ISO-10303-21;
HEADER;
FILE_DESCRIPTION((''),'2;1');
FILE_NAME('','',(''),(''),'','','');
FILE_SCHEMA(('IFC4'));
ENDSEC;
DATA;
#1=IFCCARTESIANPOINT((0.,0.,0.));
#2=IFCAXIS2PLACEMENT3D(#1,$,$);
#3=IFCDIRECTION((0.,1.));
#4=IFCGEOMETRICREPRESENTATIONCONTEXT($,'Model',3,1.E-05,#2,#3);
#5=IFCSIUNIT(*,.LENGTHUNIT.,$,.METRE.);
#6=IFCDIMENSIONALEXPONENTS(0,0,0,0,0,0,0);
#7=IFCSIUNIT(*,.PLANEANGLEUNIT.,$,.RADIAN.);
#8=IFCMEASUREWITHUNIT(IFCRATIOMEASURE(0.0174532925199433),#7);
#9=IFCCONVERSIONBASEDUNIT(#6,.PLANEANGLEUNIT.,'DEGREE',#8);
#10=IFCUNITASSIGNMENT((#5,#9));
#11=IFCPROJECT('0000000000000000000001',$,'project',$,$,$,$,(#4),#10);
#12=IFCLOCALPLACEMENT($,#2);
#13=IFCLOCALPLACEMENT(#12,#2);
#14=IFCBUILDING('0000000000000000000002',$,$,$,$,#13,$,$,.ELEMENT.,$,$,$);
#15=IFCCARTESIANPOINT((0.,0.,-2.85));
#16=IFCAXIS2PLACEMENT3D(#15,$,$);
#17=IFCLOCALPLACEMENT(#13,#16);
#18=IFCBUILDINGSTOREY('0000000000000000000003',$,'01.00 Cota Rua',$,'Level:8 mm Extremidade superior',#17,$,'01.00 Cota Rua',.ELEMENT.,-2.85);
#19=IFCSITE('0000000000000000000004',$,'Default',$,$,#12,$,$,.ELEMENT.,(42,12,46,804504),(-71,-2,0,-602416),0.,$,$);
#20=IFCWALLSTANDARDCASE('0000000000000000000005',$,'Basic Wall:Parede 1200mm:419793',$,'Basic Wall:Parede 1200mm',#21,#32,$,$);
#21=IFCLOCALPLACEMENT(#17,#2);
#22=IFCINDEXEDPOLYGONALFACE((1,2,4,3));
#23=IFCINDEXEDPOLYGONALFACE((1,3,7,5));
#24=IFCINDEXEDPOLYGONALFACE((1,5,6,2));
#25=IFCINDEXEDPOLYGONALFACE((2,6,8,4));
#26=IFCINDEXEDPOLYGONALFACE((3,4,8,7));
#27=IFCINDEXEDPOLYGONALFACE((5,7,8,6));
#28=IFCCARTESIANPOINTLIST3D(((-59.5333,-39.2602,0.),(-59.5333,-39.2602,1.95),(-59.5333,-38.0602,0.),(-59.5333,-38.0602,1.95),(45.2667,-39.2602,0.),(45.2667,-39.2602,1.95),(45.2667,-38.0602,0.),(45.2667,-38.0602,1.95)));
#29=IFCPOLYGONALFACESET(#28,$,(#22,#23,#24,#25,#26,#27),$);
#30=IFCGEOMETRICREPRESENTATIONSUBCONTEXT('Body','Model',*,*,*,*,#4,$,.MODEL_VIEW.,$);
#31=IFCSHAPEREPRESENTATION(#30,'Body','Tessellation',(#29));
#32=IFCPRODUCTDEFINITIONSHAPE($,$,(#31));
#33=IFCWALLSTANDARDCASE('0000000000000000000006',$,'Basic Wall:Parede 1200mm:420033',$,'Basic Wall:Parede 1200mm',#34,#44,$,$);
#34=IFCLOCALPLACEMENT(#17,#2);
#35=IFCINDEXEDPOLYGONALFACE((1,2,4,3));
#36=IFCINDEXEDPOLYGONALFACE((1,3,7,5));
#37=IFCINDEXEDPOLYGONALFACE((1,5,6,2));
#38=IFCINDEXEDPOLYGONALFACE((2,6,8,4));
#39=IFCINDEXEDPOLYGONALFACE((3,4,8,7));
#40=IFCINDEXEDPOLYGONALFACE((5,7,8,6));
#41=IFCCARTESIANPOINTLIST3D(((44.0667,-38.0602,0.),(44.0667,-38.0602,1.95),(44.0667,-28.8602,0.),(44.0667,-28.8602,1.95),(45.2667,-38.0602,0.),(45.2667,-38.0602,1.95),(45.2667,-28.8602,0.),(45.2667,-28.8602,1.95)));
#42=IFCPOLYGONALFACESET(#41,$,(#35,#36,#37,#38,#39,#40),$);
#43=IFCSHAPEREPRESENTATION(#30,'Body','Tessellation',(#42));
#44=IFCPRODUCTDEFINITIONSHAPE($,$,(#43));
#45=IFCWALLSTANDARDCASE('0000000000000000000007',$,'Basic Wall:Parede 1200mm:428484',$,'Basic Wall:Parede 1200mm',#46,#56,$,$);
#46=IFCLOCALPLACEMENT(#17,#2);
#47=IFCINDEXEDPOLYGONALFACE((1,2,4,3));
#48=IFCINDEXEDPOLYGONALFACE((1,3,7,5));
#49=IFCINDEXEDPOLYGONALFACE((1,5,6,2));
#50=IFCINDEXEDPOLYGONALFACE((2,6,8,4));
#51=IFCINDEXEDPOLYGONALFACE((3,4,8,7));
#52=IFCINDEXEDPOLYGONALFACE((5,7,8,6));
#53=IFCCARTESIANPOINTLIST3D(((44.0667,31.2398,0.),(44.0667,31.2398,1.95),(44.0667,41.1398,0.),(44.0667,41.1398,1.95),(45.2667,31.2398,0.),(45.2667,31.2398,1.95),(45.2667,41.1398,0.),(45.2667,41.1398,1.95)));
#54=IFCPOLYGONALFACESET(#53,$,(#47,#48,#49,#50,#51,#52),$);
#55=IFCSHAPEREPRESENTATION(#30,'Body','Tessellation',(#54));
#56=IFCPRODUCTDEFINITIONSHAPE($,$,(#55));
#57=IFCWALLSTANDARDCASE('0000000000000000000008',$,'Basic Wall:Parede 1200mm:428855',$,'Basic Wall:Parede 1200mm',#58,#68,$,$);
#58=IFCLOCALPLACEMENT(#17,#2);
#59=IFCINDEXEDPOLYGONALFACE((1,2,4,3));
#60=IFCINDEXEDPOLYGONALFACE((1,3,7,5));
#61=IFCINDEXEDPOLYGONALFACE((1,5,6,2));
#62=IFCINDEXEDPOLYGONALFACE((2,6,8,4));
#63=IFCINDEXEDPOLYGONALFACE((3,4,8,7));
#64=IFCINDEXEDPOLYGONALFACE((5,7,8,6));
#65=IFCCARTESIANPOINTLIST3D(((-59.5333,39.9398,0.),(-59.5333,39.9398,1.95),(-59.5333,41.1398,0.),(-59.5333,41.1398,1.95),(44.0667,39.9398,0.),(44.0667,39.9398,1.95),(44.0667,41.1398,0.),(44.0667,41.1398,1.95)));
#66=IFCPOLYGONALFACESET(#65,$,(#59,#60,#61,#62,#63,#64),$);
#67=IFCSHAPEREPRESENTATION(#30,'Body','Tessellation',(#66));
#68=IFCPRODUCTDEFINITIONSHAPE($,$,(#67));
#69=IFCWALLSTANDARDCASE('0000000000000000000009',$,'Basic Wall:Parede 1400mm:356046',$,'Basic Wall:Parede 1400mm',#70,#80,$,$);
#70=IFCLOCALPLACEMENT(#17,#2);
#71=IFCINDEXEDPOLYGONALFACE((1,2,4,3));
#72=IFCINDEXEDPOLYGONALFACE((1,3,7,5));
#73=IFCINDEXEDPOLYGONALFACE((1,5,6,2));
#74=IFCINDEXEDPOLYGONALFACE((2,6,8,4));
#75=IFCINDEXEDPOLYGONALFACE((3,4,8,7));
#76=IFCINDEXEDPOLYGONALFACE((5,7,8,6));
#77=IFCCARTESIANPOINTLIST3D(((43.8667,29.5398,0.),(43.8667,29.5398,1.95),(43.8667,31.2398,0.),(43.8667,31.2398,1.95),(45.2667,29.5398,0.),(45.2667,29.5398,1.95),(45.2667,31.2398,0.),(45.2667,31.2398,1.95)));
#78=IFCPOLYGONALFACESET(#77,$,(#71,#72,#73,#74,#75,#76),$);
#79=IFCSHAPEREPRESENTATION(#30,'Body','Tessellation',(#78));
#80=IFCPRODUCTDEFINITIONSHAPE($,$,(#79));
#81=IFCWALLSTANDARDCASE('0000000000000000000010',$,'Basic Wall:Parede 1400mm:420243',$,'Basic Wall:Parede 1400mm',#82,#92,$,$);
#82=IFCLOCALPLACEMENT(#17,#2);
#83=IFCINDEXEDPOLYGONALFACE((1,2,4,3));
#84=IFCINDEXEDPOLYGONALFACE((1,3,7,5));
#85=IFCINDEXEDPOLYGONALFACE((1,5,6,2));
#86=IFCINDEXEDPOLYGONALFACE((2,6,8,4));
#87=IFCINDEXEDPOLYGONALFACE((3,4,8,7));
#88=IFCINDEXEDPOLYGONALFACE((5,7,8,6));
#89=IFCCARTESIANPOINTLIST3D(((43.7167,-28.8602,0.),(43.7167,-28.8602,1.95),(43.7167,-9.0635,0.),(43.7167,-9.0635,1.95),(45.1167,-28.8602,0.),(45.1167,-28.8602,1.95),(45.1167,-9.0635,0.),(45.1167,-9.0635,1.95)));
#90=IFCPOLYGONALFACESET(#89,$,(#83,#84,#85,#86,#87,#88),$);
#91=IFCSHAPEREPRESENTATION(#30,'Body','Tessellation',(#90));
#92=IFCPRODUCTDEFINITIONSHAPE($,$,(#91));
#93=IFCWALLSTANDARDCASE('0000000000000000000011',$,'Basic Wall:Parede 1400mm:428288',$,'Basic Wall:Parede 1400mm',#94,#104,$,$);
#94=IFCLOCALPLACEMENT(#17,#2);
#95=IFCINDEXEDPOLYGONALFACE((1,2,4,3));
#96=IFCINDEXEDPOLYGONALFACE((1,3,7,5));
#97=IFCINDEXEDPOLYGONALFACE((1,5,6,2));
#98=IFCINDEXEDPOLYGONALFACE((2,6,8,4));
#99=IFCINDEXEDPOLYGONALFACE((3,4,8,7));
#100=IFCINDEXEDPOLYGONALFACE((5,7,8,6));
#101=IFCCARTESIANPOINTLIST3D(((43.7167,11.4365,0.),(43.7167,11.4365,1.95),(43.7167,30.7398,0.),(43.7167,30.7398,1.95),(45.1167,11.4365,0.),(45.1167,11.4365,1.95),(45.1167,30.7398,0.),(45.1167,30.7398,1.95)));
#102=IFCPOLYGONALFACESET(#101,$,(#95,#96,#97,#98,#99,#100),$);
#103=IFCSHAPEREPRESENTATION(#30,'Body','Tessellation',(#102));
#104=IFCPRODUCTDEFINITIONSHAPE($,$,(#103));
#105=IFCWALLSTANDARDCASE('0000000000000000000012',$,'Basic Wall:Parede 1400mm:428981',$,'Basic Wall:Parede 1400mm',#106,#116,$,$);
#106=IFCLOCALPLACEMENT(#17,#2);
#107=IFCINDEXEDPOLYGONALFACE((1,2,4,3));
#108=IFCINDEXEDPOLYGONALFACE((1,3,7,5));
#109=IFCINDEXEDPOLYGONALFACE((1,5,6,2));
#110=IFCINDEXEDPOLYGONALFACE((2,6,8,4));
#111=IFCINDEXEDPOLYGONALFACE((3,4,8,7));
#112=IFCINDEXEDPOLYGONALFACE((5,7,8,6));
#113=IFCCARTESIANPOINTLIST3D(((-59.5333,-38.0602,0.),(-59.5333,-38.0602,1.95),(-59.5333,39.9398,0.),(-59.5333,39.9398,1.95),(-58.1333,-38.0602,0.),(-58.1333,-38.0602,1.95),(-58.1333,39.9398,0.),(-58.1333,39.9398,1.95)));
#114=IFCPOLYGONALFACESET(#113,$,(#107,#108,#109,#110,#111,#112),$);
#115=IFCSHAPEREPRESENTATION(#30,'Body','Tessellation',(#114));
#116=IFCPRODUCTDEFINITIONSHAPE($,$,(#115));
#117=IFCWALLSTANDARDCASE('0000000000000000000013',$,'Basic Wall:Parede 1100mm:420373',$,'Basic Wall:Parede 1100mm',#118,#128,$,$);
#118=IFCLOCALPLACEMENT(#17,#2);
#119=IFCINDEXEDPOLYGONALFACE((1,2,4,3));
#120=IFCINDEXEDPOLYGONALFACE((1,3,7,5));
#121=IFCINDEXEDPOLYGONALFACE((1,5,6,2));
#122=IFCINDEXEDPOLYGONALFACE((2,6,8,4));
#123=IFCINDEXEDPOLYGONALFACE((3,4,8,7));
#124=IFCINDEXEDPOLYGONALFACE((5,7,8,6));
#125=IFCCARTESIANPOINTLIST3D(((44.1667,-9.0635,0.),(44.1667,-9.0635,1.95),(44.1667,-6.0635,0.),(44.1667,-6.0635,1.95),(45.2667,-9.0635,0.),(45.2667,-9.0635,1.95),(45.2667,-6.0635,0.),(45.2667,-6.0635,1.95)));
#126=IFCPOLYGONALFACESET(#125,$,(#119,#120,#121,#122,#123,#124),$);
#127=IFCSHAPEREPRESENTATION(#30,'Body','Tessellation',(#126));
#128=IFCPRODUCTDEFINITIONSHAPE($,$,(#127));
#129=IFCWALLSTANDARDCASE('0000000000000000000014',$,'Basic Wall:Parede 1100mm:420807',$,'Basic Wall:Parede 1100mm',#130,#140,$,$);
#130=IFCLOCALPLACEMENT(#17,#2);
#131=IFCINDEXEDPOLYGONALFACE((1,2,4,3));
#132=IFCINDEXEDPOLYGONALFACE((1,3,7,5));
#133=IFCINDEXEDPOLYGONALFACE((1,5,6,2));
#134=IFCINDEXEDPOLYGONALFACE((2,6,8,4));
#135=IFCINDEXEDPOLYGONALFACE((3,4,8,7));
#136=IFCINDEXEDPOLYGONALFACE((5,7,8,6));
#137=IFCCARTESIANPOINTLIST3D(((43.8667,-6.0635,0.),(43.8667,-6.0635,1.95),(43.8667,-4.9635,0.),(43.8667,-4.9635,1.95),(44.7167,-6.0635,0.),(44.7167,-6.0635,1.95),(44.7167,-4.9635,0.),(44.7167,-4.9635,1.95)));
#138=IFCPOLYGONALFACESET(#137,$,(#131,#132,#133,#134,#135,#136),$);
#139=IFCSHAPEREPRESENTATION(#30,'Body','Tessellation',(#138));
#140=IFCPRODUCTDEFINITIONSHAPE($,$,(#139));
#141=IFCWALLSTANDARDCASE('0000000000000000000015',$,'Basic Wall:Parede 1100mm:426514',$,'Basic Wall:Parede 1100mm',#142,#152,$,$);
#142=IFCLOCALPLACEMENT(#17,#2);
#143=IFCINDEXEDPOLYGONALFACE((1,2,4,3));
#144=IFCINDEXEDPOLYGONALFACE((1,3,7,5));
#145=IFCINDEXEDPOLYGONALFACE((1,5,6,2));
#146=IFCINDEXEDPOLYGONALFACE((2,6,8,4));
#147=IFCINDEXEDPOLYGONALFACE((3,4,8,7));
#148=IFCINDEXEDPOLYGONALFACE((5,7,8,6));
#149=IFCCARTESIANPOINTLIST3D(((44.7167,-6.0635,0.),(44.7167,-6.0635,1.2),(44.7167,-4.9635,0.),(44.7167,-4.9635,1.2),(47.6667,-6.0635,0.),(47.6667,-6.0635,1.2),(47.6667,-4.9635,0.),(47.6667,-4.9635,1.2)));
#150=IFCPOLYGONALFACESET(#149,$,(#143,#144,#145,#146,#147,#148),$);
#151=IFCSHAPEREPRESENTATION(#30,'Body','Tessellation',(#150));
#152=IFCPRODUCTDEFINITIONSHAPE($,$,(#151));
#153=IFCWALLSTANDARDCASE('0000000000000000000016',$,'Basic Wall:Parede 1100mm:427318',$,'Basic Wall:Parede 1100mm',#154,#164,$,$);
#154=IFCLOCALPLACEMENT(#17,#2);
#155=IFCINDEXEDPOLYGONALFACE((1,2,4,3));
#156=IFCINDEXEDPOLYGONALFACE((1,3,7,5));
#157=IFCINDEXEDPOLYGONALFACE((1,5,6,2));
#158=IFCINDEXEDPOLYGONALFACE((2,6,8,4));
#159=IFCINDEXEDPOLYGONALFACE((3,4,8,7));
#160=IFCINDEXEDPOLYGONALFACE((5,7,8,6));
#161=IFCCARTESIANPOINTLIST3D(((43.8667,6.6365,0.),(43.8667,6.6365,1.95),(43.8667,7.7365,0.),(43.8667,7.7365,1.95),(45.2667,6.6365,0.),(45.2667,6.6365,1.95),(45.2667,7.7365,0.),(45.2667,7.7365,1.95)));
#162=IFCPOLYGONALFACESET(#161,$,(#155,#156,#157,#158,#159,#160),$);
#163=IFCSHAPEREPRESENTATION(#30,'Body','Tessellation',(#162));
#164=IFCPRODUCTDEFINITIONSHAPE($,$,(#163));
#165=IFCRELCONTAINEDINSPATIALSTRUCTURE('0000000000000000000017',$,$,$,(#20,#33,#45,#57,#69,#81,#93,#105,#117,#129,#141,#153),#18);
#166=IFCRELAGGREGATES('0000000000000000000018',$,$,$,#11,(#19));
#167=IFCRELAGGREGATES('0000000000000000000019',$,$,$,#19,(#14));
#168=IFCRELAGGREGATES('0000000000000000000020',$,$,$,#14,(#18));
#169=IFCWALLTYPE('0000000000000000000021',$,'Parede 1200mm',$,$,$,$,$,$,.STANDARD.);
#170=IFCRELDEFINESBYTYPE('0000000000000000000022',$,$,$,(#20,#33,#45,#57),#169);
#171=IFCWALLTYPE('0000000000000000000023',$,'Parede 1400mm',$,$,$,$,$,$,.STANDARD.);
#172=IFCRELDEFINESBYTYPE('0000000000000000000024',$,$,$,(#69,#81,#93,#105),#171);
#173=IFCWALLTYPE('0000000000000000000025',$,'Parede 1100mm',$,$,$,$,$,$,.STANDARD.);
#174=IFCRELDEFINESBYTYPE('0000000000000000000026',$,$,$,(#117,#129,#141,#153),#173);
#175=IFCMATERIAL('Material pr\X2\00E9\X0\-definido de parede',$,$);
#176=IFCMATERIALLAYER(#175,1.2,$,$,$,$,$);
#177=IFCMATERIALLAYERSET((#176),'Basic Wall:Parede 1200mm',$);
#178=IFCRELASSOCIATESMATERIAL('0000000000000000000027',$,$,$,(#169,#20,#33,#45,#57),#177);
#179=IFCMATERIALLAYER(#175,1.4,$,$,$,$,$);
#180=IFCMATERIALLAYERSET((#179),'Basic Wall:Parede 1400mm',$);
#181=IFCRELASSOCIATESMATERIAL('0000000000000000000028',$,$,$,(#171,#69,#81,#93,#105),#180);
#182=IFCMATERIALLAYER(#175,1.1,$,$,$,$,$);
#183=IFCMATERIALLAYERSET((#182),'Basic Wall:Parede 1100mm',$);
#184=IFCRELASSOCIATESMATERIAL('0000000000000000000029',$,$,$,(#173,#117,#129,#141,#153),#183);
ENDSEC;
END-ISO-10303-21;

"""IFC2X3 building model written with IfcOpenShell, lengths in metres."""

from ifc_helpers import new_model, entity, si_unit, converted_unit, direction, frame, frame_2d, origin, place, context, subcontext, project, spatial, polyline, rectangle, extrude, clip, halfspace, bounded_halfspace, material, layer, layer_set, layer_usage, type_object, element, save


model = new_model("IFC2X3")

# Units and contexts
model_context = context("Model", 3, precision=1e-05, world=origin(), true_north=direction((0.0, 1.0)))
body_context = subcontext(model_context, "Body", "Model", "MODEL_VIEW")
ifc_project = project(units=[si_unit("LENGTHUNIT", "METRE"), converted_unit("PLANEANGLEUNIT", "DEGREE", entity("IfcRatioMeasure", 0.0174532925199433), si_unit("PLANEANGLEUNIT", "RADIAN"), dimensions=[0, 0, 0, 0, 0, 0, 0])], contexts=[model_context])

# Site, building, storey
site_placement = place(None, origin())
site = spatial("IfcSite", under=ifc_project, at=site_placement, Name="Default", CompositionType="ELEMENT", RefLatitude=(42, 12, 46, 804504), RefLongitude=(-71, -2, 0, -602416), RefElevation=0.0)
building_placement = place(site_placement, origin())
building = spatial("IfcBuilding", under=site, at=building_placement, CompositionType="ELEMENT")
storey_placement = place(building_placement, frame((0.0, 0.0, -2.85)))
storey = spatial("IfcBuildingStorey", under=building, at=storey_placement, Name="01.00 Cota Rua", ObjectType="Level:8 mm Extremidade superior", LongName="01.00 Cota Rua", CompositionType="ELEMENT", Elevation=-2.85)

# Walls
ifc_material = material(Name="Material pré-definido de parede")
ifc_layer_1 = layer(ifc_material, 1.2)
ifc_layer_set_1 = layer_set([ifc_layer_1], Name="Basic Wall:Parede 1200mm")
ifc_layer_usage_1 = layer_usage(ifc_layer_set_1, "AXIS2", "NEGATIVE", 0.6)
wall_type_1 = type_object("IfcWallType", Name="Parede 1200mm", PredefinedType="STANDARD", material=ifc_layer_set_1)
wall_1_placement = place(storey_placement, frame((45.2667, -38.6602, 0.0), z_axis=(0.0, 0.0, 1.0), x_axis=(-1.0, 0.0, 0.0)))
element("IfcWallStandardCase", 1, at=wall_1_placement, inside=storey, type_object=wall_type_1, material=ifc_layer_usage_1, Name="Basic Wall:Parede 1200mm:419793", ObjectType="Basic Wall:Parede 1200mm", context=body_context, shape_type="Clipping", body=[
    clip(extrude(rectangle(XDim=104.8, YDim=1.2, at=frame_2d((52.4, 0.0), x_axis=(-1.0, 0.0))), origin(), (0.0, 0.0, 1.0), 1.95), halfspace(origin(), True)),
])
ifc_layer_usage_2 = layer_usage(ifc_layer_set_1, "AXIS2", "POSITIVE", -0.6)
wall_2_placement = place(storey_placement, frame((44.6667, -38.0602, 0.0), z_axis=(0.0, 0.0, 1.0), x_axis=(0.0, 1.0, 0.0)))
element("IfcWallStandardCase", 2, at=wall_2_placement, inside=storey, type_object=wall_type_1, material=ifc_layer_usage_2, Name="Basic Wall:Parede 1200mm:420033", ObjectType="Basic Wall:Parede 1200mm", context=body_context, shape_type="Clipping", body=[
    clip(extrude(rectangle(XDim=9.2, YDim=1.2, at=frame_2d((4.6, 0.0), x_axis=(-1.0, 0.0))), origin(), (0.0, 0.0, 1.0), 1.95), halfspace(origin(), True)),
])
ifc_layer_usage_3 = layer_usage(ifc_layer_set_1, "AXIS2", "POSITIVE", -0.6)
wall_3_placement = place(storey_placement, frame((44.6667, 31.2398, 0.0), z_axis=(0.0, 0.0, 1.0), x_axis=(0.0, 1.0, 0.0)))
element("IfcWallStandardCase", 3, at=wall_3_placement, inside=storey, type_object=wall_type_1, material=ifc_layer_usage_3, Name="Basic Wall:Parede 1200mm:428484", ObjectType="Basic Wall:Parede 1200mm", context=body_context, shape_type="Clipping", body=[
    clip(clip(extrude(rectangle(XDim=9.9, YDim=1.2, at=frame_2d((4.95, 0.0), x_axis=(-1.0, 0.0))), origin(), (0.0, 0.0, 1.0), 1.95), bounded_halfspace(frame((0.0, -0.6, 0.0), z_axis=(1.0, 0.0, 0.0), x_axis=(0.0, -1.0, 0.0)), True, frame((0.0, -0.6, 0.0), z_axis=(1.0, 0.0, 0.0), x_axis=(0.0, -1.0, 0.0)), polyline([(0.0, 0.0), (-1.2, 0.0), (-1.2, -2.85), (0.0, -2.85), (0.0, 0.0)]))), halfspace(origin(), True)),
])
ifc_layer_usage_4 = layer_usage(ifc_layer_set_1, "AXIS2", "POSITIVE", -0.6)
wall_4_placement = place(storey_placement, frame((44.0667, 40.5398, 0.0), z_axis=(0.0, 0.0, 1.0), x_axis=(-1.0, 0.0, 0.0)))
element("IfcWallStandardCase", 4, at=wall_4_placement, inside=storey, type_object=wall_type_1, material=ifc_layer_usage_4, Name="Basic Wall:Parede 1200mm:428855", ObjectType="Basic Wall:Parede 1200mm", context=body_context, shape_type="Clipping", body=[
    clip(extrude(rectangle(XDim=103.6, YDim=1.2, at=frame_2d((51.8, 0.0), x_axis=(-1.0, 0.0))), origin(), (0.0, 0.0, 1.0), 1.95), halfspace(origin(), True)),
])
ifc_layer_2 = layer(ifc_material, 1.4)
ifc_layer_set_2 = layer_set([ifc_layer_2], Name="Basic Wall:Parede 1400mm")
ifc_layer_usage_5 = layer_usage(ifc_layer_set_2, "AXIS2", "POSITIVE", -0.7)
wall_type_2 = type_object("IfcWallType", Name="Parede 1400mm", PredefinedType="STANDARD", material=ifc_layer_set_2)
wall_5_placement = place(storey_placement, frame((44.5667, 31.2398, 0.0), z_axis=(0.0, 0.0, 1.0), x_axis=(0.0, -1.0, 0.0)))
element("IfcWallStandardCase", 5, at=wall_5_placement, inside=storey, type_object=wall_type_2, material=ifc_layer_usage_5, Name="Basic Wall:Parede 1400mm:356046", ObjectType="Basic Wall:Parede 1400mm", context=body_context, shape_type="Clipping", body=[
    clip(extrude(rectangle(XDim=1.7, YDim=1.4, at=frame_2d((0.85, 0.0), x_axis=(-1.0, 0.0))), origin(), (0.0, 0.0, 1.0), 1.95), halfspace(origin(), True)),
])
ifc_layer_usage_6 = layer_usage(ifc_layer_set_2, "AXIS2", "POSITIVE", -0.7)
wall_6_placement = place(storey_placement, frame((44.4167, -28.8602, 0.0), z_axis=(0.0, 0.0, 1.0), x_axis=(0.0, 1.0, 0.0)))
element("IfcWallStandardCase", 6, at=wall_6_placement, inside=storey, type_object=wall_type_2, material=ifc_layer_usage_6, Name="Basic Wall:Parede 1400mm:420243", ObjectType="Basic Wall:Parede 1400mm", context=body_context, shape_type="Clipping", body=[
    clip(extrude(rectangle(XDim=19.7967, YDim=1.4, at=frame_2d((9.8983, 0.0), x_axis=(-1.0, 0.0))), origin(), (0.0, 0.0, 1.0), 1.95), halfspace(origin(), True)),
])
ifc_layer_usage_7 = layer_usage(ifc_layer_set_2, "AXIS2", "POSITIVE", -0.7)
wall_7_placement = place(storey_placement, frame((44.4167, 11.4365, 0.0), z_axis=(0.0, 0.0, 1.0), x_axis=(0.0, 1.0, 0.0)))
element("IfcWallStandardCase", 7, at=wall_7_placement, inside=storey, type_object=wall_type_2, material=ifc_layer_usage_7, Name="Basic Wall:Parede 1400mm:428288", ObjectType="Basic Wall:Parede 1400mm", context=body_context, shape_type="Clipping", body=[
    clip(extrude(rectangle(XDim=19.3033, YDim=1.4, at=frame_2d((9.6517, 0.0), x_axis=(-1.0, 0.0))), origin(), (0.0, 0.0, 1.0), 1.95), halfspace(origin(), True)),
])
ifc_layer_usage_8 = layer_usage(ifc_layer_set_2, "AXIS2", "NEGATIVE", 0.7)
wall_8_placement = place(storey_placement, frame((-58.8333, 39.9398, 0.0), z_axis=(0.0, 0.0, 1.0), x_axis=(0.0, -1.0, 0.0)))
element("IfcWallStandardCase", 8, at=wall_8_placement, inside=storey, type_object=wall_type_2, material=ifc_layer_usage_8, Name="Basic Wall:Parede 1400mm:428981", ObjectType="Basic Wall:Parede 1400mm", context=body_context, shape_type="Clipping", body=[
    clip(extrude(rectangle(XDim=78.0, YDim=1.4, at=frame_2d((39.0, 0.0), x_axis=(-1.0, 0.0))), origin(), (0.0, 0.0, 1.0), 1.95), halfspace(origin(), True)),
])
ifc_layer_3 = layer(ifc_material, 1.1)
ifc_layer_set_3 = layer_set([ifc_layer_3], Name="Basic Wall:Parede 1100mm")
ifc_layer_usage_9 = layer_usage(ifc_layer_set_3, "AXIS2", "POSITIVE", -0.55)
wall_type_3 = type_object("IfcWallType", Name="Parede 1100mm", PredefinedType="STANDARD", material=ifc_layer_set_3)
wall_9_placement = place(storey_placement, frame((44.7167, -9.0635, 0.0), z_axis=(0.0, 0.0, 1.0), x_axis=(0.0, 1.0, 0.0)))
element("IfcWallStandardCase", 9, at=wall_9_placement, inside=storey, type_object=wall_type_3, material=ifc_layer_usage_9, Name="Basic Wall:Parede 1100mm:420373", ObjectType="Basic Wall:Parede 1100mm", context=body_context, shape_type="Clipping", body=[
    clip(extrude(rectangle(XDim=3.0, YDim=1.1, at=frame_2d((1.5, 0.0), x_axis=(-1.0, 0.0))), origin(), (0.0, 0.0, 1.0), 1.95), halfspace(origin(), True)),
])
ifc_layer_usage_10 = layer_usage(ifc_layer_set_3, "AXIS2", "NEGATIVE", 0.55)
wall_10_placement = place(storey_placement, frame((45.2667, -5.5135, 0.0), z_axis=(0.0, 0.0, 1.0), x_axis=(-1.0, 0.0, 0.0)))
element("IfcWallStandardCase", 10, at=wall_10_placement, inside=storey, type_object=wall_type_3, material=ifc_layer_usage_10, Name="Basic Wall:Parede 1100mm:420807", ObjectType="Basic Wall:Parede 1100mm", context=body_context, shape_type="Clipping", body=[
    clip(extrude(rectangle(XDim=0.85, YDim=1.1, at=frame_2d((0.975, 0.0), x_axis=(-1.0, 0.0))), origin(), (0.0, 0.0, 1.0), 1.95), halfspace(origin(), True)),
])
ifc_layer_usage_11 = layer_usage(ifc_layer_set_3, "AXIS2", "NEGATIVE", 0.55)
wall_11_placement = place(storey_placement, frame((47.6667, -5.5135, 0.0), z_axis=(0.0, 0.0, 1.0), x_axis=(-1.0, 0.0, 0.0)))
element("IfcWallStandardCase", 11, at=wall_11_placement, inside=storey, type_object=wall_type_3, material=ifc_layer_usage_11, Name="Basic Wall:Parede 1100mm:426514", ObjectType="Basic Wall:Parede 1100mm", context=body_context, shape_type="SweptSolid", body=[
    extrude(rectangle(XDim=2.95, YDim=1.1, at=frame_2d((1.475, 0.0), x_axis=(-1.0, 0.0))), origin(), (0.0, 0.0, 1.0), 1.2),
])
ifc_layer_usage_12 = layer_usage(ifc_layer_set_3, "AXIS2", "POSITIVE", -0.55)
wall_12_placement = place(storey_placement, frame((45.2667, 7.1865, 0.0), z_axis=(0.0, 0.0, 1.0), x_axis=(-1.0, 0.0, 0.0)))
element("IfcWallStandardCase", 12, at=wall_12_placement, inside=storey, type_object=wall_type_3, material=ifc_layer_usage_12, Name="Basic Wall:Parede 1100mm:427318", ObjectType="Basic Wall:Parede 1100mm", context=body_context, shape_type="Clipping", body=[
    clip(extrude(rectangle(XDim=1.4, YDim=1.1, at=frame_2d((0.7, 0.0), x_axis=(-1.0, 0.0))), origin(), (0.0, 0.0, 1.0), 1.95), halfspace(origin(), True)),
])

save(model, "model.ifc")
